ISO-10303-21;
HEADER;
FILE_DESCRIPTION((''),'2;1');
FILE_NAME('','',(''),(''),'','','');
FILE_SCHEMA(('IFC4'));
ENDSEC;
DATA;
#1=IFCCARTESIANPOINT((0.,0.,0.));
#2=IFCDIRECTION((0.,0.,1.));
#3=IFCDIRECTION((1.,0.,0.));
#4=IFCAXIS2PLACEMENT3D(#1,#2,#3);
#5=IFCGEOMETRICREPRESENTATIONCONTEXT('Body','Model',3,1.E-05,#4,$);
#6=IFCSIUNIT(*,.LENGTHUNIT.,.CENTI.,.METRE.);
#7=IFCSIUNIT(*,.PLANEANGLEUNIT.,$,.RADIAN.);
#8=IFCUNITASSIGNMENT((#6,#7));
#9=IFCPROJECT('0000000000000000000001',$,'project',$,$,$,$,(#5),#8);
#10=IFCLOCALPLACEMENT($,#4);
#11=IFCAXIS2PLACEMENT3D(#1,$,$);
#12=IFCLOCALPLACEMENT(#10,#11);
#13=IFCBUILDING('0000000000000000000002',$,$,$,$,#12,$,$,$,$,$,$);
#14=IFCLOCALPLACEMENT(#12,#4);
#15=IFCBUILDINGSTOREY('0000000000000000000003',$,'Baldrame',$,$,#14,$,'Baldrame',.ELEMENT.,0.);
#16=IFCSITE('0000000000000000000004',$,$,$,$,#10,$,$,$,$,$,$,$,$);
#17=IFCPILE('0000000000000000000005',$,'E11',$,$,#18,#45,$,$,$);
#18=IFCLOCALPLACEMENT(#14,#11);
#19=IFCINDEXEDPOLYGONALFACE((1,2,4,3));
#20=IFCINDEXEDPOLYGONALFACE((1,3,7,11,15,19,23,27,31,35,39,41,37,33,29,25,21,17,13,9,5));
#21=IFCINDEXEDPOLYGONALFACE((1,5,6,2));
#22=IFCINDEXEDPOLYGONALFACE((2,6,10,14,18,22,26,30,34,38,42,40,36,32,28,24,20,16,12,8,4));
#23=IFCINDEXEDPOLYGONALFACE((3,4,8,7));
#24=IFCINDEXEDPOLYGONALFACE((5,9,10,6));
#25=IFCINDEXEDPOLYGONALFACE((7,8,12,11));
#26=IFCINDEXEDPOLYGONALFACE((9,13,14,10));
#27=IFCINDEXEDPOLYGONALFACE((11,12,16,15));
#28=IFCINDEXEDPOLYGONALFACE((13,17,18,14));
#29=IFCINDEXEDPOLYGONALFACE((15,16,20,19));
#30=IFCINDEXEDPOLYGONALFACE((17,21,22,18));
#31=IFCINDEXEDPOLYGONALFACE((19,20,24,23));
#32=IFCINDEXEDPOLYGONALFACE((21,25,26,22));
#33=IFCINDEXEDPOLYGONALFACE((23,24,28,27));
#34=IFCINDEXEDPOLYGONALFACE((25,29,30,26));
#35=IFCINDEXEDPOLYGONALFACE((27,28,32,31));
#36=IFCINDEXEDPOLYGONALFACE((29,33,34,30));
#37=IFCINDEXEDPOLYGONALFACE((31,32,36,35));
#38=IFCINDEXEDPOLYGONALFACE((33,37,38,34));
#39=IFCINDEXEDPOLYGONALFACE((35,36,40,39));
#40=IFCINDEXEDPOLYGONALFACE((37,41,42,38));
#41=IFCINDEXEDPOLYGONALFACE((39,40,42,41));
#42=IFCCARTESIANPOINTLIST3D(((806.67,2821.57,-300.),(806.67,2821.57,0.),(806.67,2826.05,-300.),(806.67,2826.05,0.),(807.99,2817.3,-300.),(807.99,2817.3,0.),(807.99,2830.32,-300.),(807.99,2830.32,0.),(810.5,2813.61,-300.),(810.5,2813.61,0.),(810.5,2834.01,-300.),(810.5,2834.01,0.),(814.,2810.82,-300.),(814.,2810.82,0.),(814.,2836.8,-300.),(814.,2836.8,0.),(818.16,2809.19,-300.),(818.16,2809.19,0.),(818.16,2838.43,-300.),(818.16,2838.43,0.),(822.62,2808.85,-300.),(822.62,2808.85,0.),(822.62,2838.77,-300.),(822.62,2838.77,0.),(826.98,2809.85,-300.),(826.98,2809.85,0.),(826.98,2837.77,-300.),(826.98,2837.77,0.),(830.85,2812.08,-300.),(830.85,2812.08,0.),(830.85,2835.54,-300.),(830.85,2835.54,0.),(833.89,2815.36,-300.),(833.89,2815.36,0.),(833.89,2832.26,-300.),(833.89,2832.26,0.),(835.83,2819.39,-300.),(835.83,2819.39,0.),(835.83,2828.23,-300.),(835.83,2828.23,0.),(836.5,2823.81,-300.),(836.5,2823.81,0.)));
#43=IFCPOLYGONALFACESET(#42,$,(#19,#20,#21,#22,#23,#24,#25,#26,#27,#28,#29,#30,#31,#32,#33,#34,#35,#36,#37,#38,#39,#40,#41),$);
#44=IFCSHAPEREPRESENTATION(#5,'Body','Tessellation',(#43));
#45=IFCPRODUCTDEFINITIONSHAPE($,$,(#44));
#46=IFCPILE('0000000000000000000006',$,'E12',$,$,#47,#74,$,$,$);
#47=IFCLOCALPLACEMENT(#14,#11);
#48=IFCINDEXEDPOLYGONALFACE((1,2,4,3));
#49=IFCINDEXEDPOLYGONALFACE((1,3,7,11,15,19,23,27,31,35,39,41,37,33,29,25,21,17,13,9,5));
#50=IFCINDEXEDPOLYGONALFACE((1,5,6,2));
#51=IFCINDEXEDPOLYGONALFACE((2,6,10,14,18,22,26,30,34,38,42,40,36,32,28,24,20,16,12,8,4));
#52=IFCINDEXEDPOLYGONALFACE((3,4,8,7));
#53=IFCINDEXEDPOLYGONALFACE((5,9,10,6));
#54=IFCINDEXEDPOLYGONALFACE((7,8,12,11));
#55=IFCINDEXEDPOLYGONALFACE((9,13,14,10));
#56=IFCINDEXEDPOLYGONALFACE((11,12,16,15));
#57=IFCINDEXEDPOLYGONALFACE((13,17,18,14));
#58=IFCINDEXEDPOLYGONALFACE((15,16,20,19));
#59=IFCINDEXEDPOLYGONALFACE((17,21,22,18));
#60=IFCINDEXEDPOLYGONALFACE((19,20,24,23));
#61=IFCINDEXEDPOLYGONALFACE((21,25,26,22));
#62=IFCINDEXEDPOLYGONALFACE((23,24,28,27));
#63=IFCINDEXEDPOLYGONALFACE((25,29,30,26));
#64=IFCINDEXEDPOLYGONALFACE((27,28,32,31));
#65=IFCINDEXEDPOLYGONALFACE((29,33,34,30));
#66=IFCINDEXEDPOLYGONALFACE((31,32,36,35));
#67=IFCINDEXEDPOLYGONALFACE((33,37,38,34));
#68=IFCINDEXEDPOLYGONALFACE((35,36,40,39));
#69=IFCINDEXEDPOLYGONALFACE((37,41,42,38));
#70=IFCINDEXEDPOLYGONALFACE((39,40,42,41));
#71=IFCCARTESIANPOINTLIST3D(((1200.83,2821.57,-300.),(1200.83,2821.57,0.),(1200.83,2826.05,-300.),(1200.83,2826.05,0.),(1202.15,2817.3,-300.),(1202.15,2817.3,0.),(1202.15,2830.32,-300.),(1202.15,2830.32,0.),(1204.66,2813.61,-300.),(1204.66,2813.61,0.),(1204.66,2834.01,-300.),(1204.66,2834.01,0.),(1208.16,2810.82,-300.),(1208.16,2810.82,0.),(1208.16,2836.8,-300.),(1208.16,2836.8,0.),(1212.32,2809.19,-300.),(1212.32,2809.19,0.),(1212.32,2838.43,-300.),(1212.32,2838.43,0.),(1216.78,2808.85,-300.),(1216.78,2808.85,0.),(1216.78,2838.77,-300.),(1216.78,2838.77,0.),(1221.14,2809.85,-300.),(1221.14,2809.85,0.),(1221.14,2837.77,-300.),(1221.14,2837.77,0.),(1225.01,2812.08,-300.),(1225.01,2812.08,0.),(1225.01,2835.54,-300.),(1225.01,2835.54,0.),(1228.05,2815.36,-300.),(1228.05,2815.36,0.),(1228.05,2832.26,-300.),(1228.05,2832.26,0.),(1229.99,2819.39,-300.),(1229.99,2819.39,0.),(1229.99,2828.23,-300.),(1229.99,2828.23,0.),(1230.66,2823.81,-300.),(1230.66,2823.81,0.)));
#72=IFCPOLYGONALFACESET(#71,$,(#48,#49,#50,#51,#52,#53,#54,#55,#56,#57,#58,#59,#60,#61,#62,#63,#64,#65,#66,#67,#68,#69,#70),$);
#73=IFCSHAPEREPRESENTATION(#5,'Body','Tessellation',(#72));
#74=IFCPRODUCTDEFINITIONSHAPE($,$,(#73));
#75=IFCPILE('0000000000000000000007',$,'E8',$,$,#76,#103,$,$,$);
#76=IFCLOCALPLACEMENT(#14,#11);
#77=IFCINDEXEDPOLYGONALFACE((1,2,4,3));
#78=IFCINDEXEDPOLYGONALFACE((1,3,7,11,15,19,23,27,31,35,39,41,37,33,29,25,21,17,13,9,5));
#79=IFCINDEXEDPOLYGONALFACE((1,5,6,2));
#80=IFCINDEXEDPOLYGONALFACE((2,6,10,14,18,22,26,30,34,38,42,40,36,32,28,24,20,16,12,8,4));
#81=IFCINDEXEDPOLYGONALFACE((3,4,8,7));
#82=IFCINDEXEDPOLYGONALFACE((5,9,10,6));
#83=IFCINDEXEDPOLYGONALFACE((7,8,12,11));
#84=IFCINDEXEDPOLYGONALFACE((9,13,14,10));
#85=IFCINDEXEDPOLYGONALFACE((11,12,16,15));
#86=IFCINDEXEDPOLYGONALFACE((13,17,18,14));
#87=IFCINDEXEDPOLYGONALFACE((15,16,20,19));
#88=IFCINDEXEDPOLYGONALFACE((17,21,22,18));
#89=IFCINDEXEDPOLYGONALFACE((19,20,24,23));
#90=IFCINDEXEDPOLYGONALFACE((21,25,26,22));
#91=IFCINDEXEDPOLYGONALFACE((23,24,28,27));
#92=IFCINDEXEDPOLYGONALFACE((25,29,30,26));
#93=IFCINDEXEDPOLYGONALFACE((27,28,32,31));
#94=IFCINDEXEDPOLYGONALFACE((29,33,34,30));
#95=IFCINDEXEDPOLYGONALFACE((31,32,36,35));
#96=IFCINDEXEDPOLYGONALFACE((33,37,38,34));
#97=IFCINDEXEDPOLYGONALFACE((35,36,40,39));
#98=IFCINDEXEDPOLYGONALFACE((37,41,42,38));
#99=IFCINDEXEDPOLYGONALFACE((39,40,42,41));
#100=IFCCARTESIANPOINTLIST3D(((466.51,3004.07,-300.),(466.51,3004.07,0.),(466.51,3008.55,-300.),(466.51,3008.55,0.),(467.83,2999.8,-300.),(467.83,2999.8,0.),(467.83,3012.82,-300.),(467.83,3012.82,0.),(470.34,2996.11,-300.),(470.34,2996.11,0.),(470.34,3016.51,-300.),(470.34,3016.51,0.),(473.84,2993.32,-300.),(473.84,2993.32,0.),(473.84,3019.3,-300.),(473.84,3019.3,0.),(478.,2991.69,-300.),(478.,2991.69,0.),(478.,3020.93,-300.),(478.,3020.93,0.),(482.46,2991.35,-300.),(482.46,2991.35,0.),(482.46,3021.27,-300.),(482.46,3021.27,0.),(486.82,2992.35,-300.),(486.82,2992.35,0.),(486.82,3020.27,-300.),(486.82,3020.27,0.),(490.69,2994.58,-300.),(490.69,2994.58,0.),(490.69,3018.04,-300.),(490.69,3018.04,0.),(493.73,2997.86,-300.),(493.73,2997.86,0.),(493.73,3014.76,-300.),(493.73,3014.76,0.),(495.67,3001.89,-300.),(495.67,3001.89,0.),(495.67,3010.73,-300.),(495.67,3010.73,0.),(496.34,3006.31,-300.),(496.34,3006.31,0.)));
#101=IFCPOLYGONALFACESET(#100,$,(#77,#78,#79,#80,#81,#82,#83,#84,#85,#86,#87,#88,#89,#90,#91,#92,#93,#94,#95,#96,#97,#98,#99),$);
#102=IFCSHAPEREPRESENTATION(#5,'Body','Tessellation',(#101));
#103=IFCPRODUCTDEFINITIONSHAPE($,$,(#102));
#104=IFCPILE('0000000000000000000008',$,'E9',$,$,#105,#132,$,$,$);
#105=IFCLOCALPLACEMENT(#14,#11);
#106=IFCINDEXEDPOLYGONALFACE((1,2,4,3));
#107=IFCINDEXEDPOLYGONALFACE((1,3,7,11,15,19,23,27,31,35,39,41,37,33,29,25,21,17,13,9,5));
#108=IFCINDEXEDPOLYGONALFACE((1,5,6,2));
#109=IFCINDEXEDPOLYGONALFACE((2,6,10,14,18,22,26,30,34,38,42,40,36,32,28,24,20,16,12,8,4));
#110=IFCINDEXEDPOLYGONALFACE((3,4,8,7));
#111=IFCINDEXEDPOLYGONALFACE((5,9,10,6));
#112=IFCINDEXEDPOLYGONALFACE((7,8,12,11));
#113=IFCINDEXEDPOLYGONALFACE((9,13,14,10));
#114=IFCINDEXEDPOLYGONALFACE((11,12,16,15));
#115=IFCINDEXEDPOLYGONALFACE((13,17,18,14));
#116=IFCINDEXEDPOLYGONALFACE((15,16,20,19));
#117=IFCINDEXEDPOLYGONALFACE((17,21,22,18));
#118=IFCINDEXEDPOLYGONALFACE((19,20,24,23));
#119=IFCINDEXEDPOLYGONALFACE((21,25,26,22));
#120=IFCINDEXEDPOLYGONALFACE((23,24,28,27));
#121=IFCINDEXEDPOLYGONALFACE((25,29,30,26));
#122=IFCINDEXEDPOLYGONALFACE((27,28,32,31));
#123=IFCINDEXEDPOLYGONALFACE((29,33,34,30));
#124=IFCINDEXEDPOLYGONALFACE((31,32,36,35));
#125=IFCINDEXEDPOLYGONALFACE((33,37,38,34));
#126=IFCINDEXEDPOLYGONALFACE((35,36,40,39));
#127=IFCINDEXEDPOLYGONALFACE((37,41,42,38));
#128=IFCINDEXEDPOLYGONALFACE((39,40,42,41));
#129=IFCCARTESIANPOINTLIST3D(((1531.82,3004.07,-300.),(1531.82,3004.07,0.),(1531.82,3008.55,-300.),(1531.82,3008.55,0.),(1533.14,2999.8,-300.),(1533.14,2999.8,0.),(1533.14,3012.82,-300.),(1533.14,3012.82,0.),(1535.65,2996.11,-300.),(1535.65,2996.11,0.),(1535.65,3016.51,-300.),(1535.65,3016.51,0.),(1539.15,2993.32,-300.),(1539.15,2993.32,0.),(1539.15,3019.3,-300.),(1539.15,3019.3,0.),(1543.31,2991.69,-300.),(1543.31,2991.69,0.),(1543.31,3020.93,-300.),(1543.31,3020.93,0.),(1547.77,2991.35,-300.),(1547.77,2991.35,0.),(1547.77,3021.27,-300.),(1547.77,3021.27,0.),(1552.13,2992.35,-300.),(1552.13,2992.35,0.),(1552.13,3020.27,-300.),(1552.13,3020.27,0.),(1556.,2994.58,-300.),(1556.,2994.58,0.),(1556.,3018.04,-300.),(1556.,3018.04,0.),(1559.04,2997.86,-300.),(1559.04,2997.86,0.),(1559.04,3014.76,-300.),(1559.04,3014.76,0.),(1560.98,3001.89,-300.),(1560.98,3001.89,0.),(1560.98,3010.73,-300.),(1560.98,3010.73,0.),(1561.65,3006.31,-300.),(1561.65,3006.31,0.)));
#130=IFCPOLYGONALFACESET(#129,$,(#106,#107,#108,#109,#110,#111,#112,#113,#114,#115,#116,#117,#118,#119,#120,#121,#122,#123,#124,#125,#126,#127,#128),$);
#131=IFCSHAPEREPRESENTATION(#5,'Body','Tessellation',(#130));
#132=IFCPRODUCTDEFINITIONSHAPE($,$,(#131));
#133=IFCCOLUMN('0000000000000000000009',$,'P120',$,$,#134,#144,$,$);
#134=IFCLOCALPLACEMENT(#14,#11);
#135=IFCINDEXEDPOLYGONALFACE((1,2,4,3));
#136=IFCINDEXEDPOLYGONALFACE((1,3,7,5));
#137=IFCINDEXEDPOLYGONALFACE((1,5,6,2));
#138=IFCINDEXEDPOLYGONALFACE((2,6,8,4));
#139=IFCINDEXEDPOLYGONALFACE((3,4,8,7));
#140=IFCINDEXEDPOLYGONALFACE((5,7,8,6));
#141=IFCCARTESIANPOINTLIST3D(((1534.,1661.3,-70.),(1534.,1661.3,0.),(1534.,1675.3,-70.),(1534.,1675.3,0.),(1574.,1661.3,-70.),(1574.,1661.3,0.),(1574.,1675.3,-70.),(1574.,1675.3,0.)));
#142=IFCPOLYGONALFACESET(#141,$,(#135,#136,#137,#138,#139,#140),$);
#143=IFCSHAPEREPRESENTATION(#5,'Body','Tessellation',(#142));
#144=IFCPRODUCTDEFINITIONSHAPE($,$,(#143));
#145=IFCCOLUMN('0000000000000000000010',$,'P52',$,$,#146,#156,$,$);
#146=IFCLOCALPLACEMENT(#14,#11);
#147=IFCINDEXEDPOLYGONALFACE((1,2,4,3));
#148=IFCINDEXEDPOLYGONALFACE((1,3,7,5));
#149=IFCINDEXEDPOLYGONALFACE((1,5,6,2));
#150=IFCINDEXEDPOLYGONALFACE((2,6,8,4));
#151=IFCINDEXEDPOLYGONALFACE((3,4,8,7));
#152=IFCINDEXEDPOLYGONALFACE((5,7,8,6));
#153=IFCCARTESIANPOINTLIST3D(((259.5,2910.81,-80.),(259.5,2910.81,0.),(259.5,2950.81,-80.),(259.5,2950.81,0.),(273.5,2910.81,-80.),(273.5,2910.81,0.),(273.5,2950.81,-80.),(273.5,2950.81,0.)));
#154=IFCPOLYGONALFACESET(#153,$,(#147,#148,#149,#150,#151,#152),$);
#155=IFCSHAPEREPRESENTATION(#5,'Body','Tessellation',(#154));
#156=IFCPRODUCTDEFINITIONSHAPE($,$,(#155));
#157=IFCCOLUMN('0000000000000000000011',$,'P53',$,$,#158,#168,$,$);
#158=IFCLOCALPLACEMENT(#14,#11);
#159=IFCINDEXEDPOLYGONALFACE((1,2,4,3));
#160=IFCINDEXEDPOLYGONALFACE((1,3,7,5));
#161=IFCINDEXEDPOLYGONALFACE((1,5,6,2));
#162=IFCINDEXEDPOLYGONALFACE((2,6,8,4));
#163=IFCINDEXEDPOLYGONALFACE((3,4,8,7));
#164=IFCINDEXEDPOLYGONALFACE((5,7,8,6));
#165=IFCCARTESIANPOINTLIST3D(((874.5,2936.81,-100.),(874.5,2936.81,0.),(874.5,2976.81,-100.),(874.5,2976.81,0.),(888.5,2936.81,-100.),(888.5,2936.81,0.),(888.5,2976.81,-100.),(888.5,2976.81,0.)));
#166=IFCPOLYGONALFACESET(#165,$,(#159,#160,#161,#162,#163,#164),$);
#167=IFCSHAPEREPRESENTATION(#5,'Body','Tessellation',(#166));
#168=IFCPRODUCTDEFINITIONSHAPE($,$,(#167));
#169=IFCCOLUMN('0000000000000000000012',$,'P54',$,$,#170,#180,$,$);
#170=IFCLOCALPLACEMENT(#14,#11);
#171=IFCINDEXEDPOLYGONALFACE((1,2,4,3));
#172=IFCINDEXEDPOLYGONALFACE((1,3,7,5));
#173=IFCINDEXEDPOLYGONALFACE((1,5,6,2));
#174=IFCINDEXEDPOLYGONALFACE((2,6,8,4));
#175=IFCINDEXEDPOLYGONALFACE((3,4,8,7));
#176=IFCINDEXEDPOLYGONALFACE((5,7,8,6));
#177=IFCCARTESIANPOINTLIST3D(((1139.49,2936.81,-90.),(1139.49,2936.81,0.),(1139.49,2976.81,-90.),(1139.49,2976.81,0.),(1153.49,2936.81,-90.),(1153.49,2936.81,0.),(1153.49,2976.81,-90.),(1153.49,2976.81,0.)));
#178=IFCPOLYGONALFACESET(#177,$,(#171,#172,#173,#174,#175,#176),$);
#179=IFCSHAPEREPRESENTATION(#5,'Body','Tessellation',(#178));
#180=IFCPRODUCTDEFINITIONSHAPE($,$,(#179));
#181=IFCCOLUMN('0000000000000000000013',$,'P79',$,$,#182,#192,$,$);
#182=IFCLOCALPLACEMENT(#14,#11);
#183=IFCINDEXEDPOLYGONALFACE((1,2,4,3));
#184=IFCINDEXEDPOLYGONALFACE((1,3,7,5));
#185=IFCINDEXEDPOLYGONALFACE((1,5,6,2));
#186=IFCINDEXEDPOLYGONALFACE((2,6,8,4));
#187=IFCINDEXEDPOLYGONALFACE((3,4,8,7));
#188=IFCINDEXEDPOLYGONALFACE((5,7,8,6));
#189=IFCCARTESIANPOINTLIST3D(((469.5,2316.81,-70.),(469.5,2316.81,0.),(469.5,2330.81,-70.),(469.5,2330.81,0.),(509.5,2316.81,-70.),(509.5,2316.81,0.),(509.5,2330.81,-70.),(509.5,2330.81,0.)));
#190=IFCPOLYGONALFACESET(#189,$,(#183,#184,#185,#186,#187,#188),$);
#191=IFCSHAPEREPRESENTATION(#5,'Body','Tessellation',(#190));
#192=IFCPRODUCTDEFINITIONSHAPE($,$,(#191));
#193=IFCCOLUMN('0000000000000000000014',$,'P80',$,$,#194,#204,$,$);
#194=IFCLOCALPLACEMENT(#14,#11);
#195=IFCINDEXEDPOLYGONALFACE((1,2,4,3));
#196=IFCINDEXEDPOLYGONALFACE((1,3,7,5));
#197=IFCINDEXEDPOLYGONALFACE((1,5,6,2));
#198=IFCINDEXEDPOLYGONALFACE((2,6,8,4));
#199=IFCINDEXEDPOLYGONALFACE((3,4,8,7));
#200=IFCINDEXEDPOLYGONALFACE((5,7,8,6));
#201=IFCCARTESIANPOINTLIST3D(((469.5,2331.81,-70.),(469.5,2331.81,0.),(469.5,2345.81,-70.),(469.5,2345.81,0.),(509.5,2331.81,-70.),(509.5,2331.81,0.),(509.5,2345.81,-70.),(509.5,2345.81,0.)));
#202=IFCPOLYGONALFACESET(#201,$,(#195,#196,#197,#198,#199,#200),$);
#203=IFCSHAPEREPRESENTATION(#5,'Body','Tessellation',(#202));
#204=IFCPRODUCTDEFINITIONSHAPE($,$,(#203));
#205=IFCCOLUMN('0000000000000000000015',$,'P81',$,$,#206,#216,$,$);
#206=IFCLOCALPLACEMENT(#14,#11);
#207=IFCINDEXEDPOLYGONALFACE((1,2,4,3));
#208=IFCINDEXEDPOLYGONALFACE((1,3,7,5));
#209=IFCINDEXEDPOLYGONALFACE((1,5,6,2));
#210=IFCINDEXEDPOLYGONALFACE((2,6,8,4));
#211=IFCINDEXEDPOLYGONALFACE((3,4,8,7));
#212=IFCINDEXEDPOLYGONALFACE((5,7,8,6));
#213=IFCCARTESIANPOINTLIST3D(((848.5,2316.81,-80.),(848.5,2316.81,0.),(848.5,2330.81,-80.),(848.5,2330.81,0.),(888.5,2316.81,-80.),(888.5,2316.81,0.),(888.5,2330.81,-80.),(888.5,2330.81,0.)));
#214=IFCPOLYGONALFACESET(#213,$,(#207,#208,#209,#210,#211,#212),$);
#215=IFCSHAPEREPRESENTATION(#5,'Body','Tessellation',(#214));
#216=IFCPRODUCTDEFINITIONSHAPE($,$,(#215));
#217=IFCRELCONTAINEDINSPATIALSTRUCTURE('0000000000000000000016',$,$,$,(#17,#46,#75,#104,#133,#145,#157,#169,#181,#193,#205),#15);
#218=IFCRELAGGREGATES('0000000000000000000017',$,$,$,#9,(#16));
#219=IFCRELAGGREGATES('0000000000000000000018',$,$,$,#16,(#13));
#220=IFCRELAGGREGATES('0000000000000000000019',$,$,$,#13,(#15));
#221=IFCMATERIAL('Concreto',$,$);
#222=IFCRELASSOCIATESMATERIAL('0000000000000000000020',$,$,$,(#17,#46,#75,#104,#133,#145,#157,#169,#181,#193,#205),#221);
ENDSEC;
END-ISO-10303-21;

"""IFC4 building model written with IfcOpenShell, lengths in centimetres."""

from ifc_helpers import new_model, si_unit, frame, origin, origin_with_axes, origin_2d_with_axis, place, context, project, spatial, rectangle, circle, extrude, material, element, save


model = new_model("IFC4")

# Units and contexts
model_context = context("Model", 3, precision=1e-05, world=origin_with_axes(), identifier="Body")
ifc_project = project(units=[si_unit("LENGTHUNIT", "METRE", prefix="CENTI"), si_unit("PLANEANGLEUNIT", "RADIAN")], contexts=[model_context])

# Site, building, storey
site_placement = place(None, origin_with_axes())
site = spatial("IfcSite", under=ifc_project, at=site_placement)
building_placement = place(site_placement, origin())
building = spatial("IfcBuilding", under=site, at=building_placement)
storey_placement = place(building_placement, origin_with_axes())
storey = spatial("IfcBuildingStorey", under=building, at=storey_placement, Name="Baldrame", LongName="Baldrame", CompositionType="ELEMENT", Elevation=0.0)

# Piles
ifc_material = material(Name="Concreto")
for number, where, z_axis, x_axis, name in (
    (1, (821.5, 2823.81, 0.0), (0.0, 0.0, 1.0), (1.0, 0.0, 0.0), "E11"),
    (2, (1215.66, 2823.81, 0.0), (0.0, 0.0, 1.0), (1.0, 0.0, 0.0), "E12"),
    (3, (481.34, 3006.31, 0.0), (0.0, 0.0, 1.0), (1.0, 0.0, 0.0), "E8"),
    (4, (1546.65, 3006.31, 0.0), (0.0, 0.0, 1.0), (1.0, 0.0, 0.0), "E9"),
):
    element("IfcPile", number, at=place(storey_placement, frame(where, z_axis=z_axis, x_axis=x_axis)), inside=storey, material=ifc_material, Name=name, context=model_context, shape_type="SolidModel", body=[
        extrude(circle(Radius=15.0, at=origin_2d_with_axis()), frame((0.0, 0.0, -300.0), z_axis=(0.0, 0.0, 1.0), x_axis=(1.0, 0.0, 0.0)), (0.0, 0.0, 1.0), 300.0),
    ])

# Columns
column_1_placement = place(storey_placement, frame((1554.0, 1668.3, 0.0), z_axis=(0.0, 0.0, 1.0), x_axis=(1.0, 0.0, 0.0)))
element("IfcColumn", 5, at=column_1_placement, inside=storey, material=ifc_material, Name="P120", context=model_context, shape_type="SolidModel", body=[
    extrude(rectangle(XDim=14.0, YDim=40.0, at=origin_2d_with_axis()), frame((0.0, 0.0, -70.0), z_axis=(0.0, 0.0, 1.0), x_axis=(0.0, -1.0, 0.0)), (0.0, 0.0, 1.0), 70.0),
])
column_2_placement = place(storey_placement, frame((266.5, 2930.81, 0.0), z_axis=(0.0, 0.0, 1.0), x_axis=(1.0, 0.0, 0.0)))
element("IfcColumn", 6, at=column_2_placement, inside=storey, material=ifc_material, Name="P52", context=model_context, shape_type="SolidModel", body=[
    extrude(rectangle(XDim=14.0, YDim=40.0, at=origin_2d_with_axis()), frame((0.0, 0.0, -80.0), z_axis=(0.0, 0.0, 1.0), x_axis=(1.0, 0.0, 0.0)), (0.0, 0.0, 1.0), 80.0),
])
column_3_placement = place(storey_placement, frame((881.5, 2956.81, 0.0), z_axis=(0.0, 0.0, 1.0), x_axis=(1.0, 0.0, 0.0)))
element("IfcColumn", 7, at=column_3_placement, inside=storey, material=ifc_material, Name="P53", context=model_context, shape_type="SolidModel", body=[
    extrude(rectangle(XDim=14.0, YDim=40.0, at=origin_2d_with_axis()), frame((0.0, 0.0, -100.0), z_axis=(0.0, 0.0, 1.0), x_axis=(1.0, 0.0, 0.0)), (0.0, 0.0, 1.0), 100.0),
])
column_4_placement = place(storey_placement, frame((1146.49, 2956.81, 0.0), z_axis=(0.0, 0.0, 1.0), x_axis=(1.0, 0.0, 0.0)))
element("IfcColumn", 8, at=column_4_placement, inside=storey, material=ifc_material, Name="P54", context=model_context, shape_type="SolidModel", body=[
    extrude(rectangle(XDim=14.0, YDim=40.0, at=origin_2d_with_axis()), frame((0.0, 0.0, -90.0), z_axis=(0.0, 0.0, 1.0), x_axis=(1.0, 0.0, 0.0)), (0.0, 0.0, 1.0), 90.0),
])
for number, where, z_axis, x_axis, name in (
    (9, (489.5, 2323.81, 0.0), (0.0, 0.0, 1.0), (1.0, 0.0, 0.0), "P79"),
    (10, (489.5, 2338.81, 0.0), (0.0, 0.0, 1.0), (1.0, 0.0, 0.0), "P80"),
):
    element("IfcColumn", number, at=place(storey_placement, frame(where, z_axis=z_axis, x_axis=x_axis)), inside=storey, material=ifc_material, Name=name, context=model_context, shape_type="SolidModel", body=[
        extrude(rectangle(XDim=14.0, YDim=40.0, at=origin_2d_with_axis()), frame((0.0, 0.0, -70.0), z_axis=(0.0, 0.0, 1.0), x_axis=(0.0, 1.0, 0.0)), (0.0, 0.0, 1.0), 70.0),
    ])
for number, where, z_axis, x_axis, name in (
    (11, (868.5, 2323.81, 0.0), (0.0, 0.0, 1.0), (1.0, 0.0, 0.0), "P81"),
):
    element("IfcColumn", number, at=place(storey_placement, frame(where, z_axis=z_axis, x_axis=x_axis)), inside=storey, material=ifc_material, Name=name, context=model_context, shape_type="SolidModel", body=[
        extrude(rectangle(XDim=14.0, YDim=40.0, at=origin_2d_with_axis()), frame((0.0, 0.0, -80.0), z_axis=(0.0, 0.0, 1.0), x_axis=(0.0, -1.0, 0.0)), (0.0, 0.0, 1.0), 80.0),
    ])

save(model, "model.ifc")
